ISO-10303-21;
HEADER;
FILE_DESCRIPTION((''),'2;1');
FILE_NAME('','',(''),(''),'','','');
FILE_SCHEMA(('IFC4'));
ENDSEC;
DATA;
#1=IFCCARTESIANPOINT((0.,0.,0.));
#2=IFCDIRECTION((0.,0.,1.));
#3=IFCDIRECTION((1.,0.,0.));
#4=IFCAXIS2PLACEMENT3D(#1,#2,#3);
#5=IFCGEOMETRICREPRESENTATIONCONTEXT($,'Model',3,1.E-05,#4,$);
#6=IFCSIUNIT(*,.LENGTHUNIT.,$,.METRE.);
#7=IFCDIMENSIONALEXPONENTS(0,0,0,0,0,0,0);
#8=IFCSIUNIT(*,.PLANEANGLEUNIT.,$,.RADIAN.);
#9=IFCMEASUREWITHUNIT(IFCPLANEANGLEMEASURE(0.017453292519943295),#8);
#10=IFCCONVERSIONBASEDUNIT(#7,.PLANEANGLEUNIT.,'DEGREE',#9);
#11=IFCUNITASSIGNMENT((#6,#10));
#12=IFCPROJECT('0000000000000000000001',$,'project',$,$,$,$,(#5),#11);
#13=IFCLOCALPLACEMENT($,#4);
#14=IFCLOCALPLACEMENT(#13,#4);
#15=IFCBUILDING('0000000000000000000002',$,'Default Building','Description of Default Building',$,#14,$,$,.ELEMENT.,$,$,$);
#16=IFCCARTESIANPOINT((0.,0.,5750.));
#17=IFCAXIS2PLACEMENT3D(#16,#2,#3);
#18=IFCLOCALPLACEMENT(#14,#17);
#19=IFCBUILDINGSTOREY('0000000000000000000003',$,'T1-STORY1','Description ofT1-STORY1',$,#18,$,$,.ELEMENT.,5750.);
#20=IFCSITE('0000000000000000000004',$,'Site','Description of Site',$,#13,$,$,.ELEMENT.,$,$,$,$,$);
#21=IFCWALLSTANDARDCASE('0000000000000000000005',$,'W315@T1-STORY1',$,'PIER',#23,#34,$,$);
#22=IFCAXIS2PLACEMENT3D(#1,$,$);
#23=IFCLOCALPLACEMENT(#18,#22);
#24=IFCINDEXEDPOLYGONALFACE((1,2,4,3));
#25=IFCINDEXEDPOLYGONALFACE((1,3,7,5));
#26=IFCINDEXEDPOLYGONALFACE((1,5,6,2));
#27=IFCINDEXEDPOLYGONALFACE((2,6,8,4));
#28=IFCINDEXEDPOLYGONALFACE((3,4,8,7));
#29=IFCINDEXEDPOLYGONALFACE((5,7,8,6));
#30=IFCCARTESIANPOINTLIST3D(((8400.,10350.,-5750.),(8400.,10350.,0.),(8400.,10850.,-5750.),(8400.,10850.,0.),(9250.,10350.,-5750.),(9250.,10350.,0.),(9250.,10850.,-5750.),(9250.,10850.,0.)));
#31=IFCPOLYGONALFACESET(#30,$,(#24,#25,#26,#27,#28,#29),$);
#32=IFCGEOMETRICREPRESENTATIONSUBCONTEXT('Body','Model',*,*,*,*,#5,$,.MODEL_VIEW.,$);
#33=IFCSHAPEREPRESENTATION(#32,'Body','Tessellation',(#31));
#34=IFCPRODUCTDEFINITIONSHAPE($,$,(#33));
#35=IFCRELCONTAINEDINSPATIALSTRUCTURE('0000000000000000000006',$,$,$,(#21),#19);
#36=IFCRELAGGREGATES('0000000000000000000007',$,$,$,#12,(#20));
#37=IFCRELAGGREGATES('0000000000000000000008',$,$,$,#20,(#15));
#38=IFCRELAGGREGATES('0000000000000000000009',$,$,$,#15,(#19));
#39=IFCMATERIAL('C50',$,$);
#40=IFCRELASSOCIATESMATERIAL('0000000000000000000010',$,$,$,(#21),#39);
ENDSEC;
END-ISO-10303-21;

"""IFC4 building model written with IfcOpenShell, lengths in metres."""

from ifc_helpers import new_model, entity, si_unit, converted_unit, frame, origin_with_axes, place, context, subcontext, project, spatial, indexed_curve, outline, extrude, material, element, save


model = new_model("IFC4")

# Units and contexts
model_context = context("Model", 3, precision=1e-05, world=origin_with_axes())
body_context = subcontext(model_context, "Body", "Model", "MODEL_VIEW")
ifc_project = project(units=[si_unit("LENGTHUNIT", "METRE"), converted_unit("PLANEANGLEUNIT", "DEGREE", entity("IfcPlaneAngleMeasure", 0.017453292519943295), si_unit("PLANEANGLEUNIT", "RADIAN"), dimensions=[0, 0, 0, 0, 0, 0, 0])], contexts=[model_context])

# Site, building, storey
site_placement = place(None, origin_with_axes())
site = spatial("IfcSite", under=ifc_project, at=site_placement, Name="Site", Description="Description of Site", CompositionType="ELEMENT")
building_placement = place(site_placement, origin_with_axes())
building = spatial("IfcBuilding", under=site, at=building_placement, Name="Default Building", Description="Description of Default Building", CompositionType="ELEMENT")
storey_placement = place(building_placement, frame((0.0, 0.0, 5750.0), z_axis=(0.0, 0.0, 1.0), x_axis=(1.0, 0.0, 0.0)))
storey = spatial("IfcBuildingStorey", under=building, at=storey_placement, Name="T1-STORY1", Description="Description ofT1-STORY1", CompositionType="ELEMENT", Elevation=5750.0)

# Shared definitions
ifc_material_1 = material(Name="C50")

# Wall
wall_1_placement = place(storey_placement, frame((8400.0, 10600.0, -5750.0), z_axis=(0.0, 0.0, 1.0), x_axis=(1.0, 0.0, 0.0)))
element("IfcWallStandardCase", 1, at=wall_1_placement, inside=storey, material=ifc_material_1, Name="W315@T1-STORY1", ObjectType="PIER", context=body_context, shape_type="SweptSolid", body=[
    extrude(outline(indexed_curve([(0.0, -250.0), (0.0, 250.0), (850.0, 250.0), (850.0, -250.0), (0.0, -250.0)], self_intersect=False)), origin_with_axes(), (0.0, 0.0, 1.0), 5750.0),
])

save(model, "model.ifc")
